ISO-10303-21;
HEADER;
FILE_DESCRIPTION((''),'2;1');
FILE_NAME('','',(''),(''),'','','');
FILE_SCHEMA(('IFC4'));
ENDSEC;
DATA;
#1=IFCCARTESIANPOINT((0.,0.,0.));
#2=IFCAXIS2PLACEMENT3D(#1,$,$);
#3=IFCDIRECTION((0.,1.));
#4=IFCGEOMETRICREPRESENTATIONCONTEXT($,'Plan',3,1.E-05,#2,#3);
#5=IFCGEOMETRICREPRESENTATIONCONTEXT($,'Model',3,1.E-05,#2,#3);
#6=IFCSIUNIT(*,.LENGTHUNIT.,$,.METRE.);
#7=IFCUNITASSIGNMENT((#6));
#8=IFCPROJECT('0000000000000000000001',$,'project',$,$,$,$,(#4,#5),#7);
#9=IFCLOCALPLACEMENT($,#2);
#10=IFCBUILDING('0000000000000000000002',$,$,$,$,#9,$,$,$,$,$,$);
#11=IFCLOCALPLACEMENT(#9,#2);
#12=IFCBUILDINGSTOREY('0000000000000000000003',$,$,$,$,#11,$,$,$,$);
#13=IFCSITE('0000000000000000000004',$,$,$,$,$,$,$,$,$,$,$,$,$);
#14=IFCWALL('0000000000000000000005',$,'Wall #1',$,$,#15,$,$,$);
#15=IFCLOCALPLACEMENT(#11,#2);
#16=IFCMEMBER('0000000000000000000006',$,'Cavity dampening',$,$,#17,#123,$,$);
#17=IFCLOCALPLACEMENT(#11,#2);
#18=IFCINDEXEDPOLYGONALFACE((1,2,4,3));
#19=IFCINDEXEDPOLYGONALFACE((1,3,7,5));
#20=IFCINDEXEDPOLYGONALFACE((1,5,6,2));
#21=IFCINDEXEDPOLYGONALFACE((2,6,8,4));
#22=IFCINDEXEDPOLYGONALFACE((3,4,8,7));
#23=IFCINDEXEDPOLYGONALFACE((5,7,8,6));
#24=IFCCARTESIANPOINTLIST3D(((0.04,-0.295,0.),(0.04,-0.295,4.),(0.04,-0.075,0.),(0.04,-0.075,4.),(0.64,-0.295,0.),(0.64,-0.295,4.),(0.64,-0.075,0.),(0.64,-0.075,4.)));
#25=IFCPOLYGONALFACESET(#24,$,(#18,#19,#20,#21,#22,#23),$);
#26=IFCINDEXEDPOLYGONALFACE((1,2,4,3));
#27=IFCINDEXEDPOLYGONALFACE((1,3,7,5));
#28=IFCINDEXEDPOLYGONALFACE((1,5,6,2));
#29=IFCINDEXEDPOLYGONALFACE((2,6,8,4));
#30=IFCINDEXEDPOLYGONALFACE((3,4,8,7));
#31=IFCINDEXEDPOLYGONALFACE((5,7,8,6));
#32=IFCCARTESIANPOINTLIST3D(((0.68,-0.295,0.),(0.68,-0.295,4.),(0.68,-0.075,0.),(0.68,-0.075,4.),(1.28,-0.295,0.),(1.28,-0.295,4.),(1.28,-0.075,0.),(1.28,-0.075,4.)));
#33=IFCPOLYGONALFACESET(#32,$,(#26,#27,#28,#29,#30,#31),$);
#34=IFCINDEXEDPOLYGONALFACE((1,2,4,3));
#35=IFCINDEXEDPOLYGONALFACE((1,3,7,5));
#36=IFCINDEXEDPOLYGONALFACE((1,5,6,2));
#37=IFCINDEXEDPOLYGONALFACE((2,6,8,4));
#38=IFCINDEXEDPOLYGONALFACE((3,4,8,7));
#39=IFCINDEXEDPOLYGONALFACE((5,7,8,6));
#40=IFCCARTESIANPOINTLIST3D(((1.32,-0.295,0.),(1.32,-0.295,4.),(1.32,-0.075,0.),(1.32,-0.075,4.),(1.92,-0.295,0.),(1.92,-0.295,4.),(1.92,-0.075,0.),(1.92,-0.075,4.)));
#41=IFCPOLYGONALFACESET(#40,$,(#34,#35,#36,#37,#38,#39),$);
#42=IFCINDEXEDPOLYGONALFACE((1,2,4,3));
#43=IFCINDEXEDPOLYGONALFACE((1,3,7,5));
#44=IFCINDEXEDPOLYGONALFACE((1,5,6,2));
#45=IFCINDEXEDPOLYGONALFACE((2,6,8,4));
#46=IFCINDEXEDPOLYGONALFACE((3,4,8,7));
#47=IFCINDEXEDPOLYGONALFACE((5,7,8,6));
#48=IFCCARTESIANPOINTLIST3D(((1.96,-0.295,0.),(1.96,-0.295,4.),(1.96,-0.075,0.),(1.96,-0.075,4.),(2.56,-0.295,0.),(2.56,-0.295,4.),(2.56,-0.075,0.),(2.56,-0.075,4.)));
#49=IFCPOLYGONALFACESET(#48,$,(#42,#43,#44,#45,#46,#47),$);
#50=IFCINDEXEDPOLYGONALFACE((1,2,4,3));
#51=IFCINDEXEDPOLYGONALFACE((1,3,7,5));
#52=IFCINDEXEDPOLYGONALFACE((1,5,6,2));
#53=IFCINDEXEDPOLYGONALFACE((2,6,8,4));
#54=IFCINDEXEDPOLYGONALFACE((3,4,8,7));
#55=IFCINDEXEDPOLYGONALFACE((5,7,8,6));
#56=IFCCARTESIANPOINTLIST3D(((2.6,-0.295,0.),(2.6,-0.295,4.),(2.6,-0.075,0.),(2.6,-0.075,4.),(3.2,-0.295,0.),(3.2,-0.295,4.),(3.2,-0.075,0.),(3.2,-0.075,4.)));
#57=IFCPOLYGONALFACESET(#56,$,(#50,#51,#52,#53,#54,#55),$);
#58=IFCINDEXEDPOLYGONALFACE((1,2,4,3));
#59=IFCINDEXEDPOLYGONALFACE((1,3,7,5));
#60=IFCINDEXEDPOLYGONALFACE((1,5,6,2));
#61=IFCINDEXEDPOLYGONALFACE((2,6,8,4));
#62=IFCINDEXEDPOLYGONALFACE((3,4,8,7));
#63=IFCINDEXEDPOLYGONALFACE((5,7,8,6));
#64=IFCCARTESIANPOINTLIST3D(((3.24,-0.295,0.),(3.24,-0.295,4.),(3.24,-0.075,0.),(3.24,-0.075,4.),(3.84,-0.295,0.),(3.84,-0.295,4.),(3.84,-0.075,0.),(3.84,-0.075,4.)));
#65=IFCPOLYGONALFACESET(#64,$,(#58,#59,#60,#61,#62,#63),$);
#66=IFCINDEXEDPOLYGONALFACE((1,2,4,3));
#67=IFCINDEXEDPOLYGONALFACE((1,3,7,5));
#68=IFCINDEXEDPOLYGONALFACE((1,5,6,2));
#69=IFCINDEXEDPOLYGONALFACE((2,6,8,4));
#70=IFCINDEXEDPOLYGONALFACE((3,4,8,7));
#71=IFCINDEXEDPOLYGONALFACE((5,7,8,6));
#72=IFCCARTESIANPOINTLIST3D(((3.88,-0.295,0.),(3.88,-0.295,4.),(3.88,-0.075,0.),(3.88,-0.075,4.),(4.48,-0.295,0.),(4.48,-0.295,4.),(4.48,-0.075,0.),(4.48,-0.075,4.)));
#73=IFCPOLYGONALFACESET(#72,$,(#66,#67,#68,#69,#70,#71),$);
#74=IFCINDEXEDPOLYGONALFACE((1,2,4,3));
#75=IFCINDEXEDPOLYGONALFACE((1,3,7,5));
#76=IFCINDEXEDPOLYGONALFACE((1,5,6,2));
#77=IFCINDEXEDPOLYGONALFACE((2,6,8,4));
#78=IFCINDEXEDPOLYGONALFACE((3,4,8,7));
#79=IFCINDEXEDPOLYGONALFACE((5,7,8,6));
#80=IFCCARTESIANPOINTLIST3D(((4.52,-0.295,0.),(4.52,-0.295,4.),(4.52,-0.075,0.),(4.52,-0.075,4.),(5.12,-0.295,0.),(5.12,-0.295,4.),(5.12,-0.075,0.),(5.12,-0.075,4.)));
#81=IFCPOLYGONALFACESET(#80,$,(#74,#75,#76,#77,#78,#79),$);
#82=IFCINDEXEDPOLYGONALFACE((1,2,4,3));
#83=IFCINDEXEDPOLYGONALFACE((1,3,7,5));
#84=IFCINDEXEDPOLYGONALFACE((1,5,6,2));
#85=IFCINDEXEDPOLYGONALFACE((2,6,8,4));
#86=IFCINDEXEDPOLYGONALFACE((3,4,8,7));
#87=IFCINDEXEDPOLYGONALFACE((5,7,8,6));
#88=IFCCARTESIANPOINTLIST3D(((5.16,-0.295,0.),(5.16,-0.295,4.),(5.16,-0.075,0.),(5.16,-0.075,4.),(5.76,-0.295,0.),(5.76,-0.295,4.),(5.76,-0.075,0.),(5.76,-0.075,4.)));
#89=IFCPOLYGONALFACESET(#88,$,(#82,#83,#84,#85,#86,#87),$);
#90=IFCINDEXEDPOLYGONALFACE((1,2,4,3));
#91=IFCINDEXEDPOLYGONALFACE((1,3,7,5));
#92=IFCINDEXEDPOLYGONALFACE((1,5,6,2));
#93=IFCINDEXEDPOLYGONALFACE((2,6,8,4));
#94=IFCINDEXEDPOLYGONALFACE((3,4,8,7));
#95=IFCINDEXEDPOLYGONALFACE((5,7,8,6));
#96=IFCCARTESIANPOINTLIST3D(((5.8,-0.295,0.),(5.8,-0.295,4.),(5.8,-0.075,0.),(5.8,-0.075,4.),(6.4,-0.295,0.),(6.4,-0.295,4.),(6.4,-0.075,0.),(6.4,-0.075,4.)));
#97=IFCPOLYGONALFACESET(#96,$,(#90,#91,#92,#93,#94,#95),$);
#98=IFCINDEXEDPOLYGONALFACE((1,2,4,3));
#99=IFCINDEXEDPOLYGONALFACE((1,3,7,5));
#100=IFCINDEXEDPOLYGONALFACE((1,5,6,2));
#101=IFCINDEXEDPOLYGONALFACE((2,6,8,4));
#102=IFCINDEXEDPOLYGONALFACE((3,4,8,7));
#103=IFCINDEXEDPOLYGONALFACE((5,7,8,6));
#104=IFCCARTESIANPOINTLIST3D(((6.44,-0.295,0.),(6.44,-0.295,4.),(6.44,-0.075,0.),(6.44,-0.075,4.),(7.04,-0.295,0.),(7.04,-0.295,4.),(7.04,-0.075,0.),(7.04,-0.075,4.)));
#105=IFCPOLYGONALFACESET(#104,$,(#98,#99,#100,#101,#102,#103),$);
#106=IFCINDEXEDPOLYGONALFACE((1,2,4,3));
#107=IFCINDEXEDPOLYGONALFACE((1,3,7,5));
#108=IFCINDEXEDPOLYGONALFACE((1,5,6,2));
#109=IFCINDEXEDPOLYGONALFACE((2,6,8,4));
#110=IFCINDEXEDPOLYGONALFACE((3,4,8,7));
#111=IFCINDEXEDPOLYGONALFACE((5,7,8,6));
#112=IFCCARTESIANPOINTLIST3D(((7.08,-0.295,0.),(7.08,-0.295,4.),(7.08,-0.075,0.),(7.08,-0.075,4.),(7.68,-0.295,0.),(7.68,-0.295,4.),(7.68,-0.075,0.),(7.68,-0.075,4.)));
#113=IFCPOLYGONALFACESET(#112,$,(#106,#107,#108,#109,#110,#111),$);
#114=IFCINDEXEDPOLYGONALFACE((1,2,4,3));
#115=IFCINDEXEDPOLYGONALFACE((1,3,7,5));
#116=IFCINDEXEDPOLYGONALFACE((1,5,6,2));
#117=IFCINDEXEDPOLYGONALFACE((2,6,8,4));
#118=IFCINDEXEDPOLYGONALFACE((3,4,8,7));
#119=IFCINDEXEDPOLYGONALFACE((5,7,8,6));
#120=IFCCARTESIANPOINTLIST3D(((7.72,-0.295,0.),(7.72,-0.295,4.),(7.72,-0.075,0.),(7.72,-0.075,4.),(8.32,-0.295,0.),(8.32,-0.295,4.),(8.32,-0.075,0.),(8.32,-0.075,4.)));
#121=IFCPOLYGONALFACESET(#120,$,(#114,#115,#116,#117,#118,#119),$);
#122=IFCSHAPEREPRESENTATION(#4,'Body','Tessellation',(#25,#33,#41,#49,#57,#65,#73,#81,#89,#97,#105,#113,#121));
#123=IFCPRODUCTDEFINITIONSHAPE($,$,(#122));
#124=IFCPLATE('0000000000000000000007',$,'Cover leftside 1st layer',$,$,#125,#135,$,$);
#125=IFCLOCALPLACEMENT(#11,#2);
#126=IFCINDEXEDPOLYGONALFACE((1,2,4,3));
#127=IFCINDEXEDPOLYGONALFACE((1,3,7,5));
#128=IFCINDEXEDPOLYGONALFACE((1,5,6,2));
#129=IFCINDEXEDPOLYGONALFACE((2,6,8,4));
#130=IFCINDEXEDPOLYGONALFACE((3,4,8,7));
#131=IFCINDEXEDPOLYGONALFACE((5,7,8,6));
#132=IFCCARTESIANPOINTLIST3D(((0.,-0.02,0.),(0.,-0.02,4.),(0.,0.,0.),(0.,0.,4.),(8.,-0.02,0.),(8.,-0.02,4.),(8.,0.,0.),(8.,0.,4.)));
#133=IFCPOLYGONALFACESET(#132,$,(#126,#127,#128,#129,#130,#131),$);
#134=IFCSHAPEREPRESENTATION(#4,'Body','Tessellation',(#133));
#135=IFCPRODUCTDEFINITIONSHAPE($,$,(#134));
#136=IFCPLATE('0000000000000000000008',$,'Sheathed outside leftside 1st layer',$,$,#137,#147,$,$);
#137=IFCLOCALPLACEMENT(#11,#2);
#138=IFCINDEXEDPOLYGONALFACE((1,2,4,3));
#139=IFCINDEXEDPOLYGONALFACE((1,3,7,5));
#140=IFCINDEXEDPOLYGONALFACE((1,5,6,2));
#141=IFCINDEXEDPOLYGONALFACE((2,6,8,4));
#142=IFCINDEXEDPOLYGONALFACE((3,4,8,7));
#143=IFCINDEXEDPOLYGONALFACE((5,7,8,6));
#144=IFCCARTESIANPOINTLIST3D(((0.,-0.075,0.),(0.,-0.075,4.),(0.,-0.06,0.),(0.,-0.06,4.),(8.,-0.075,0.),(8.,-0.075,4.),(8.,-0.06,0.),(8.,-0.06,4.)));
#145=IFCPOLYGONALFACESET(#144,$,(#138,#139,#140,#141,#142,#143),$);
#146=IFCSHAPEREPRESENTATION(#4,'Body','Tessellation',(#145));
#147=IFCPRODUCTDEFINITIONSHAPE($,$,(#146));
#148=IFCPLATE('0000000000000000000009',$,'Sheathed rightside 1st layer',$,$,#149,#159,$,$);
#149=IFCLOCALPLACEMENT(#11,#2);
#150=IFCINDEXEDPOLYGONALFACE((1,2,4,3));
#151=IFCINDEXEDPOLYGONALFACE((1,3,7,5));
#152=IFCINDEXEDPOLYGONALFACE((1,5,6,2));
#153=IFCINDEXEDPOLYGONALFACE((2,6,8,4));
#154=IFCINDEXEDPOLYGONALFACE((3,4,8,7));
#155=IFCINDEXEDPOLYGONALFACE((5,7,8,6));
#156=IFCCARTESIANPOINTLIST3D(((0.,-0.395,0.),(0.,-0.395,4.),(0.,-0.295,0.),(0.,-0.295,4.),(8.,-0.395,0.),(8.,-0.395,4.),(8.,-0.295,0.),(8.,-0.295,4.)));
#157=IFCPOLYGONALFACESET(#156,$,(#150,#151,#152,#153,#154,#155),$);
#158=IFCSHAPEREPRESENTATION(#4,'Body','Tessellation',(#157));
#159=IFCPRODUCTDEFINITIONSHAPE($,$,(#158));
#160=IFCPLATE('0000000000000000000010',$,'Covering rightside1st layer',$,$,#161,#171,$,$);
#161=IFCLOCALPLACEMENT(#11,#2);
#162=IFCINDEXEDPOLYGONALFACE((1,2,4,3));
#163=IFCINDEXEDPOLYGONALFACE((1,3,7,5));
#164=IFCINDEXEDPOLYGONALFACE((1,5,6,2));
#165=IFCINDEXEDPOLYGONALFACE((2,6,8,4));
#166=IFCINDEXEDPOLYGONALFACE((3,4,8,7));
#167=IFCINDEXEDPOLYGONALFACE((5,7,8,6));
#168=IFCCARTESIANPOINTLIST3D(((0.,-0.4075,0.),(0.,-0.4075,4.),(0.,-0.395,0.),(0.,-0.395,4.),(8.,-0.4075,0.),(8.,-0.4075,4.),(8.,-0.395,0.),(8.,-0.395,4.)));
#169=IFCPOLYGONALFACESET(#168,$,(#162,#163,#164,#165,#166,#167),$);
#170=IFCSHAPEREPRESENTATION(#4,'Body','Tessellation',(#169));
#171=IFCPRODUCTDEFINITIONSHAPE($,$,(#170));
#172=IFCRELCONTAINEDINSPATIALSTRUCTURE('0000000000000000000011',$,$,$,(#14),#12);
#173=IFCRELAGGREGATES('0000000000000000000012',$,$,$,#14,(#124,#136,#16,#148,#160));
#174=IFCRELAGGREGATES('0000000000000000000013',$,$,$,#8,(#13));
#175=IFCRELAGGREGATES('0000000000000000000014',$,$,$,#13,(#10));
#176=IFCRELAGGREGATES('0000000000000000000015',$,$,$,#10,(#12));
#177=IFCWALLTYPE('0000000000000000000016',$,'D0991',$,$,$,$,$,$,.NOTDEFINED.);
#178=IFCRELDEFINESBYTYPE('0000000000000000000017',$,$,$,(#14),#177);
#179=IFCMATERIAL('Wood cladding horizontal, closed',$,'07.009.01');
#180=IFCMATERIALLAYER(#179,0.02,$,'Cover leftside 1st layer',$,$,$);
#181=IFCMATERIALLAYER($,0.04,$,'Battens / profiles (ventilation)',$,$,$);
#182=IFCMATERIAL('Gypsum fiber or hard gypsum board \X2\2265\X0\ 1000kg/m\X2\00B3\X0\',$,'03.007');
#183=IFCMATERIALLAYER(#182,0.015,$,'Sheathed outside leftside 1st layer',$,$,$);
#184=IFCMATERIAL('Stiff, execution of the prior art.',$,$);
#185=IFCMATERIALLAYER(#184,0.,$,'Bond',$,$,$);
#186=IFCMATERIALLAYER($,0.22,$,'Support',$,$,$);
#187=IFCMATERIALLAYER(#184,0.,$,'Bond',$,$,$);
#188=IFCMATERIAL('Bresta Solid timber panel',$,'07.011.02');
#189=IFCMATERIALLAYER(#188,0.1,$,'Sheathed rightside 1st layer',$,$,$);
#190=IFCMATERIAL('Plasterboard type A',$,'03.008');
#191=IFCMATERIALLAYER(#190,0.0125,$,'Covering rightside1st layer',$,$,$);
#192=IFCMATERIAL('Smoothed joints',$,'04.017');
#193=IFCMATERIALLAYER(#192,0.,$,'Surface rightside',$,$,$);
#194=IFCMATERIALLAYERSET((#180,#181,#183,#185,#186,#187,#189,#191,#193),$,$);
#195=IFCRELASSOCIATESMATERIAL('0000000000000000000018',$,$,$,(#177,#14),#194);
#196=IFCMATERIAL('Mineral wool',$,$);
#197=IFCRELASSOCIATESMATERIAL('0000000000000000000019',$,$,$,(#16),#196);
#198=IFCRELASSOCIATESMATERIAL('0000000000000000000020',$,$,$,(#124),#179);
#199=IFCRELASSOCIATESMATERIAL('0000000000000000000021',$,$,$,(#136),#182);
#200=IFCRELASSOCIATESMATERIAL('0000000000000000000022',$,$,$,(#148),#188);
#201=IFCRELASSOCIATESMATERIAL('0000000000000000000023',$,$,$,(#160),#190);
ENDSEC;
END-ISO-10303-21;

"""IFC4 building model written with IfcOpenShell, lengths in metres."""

from ifc_helpers import new_model, si_unit, direction, frame, frame_2d, origin, origin_with_axes, place, context, project, spatial, rectangle, extrude, material, layer, layer_set, type_object, element, aggregate, save


model = new_model("IFC4")

# Units and contexts
plan_context = context("Plan", 3, precision=1e-05, world=origin(), true_north=direction((0.0, 1.0)))
model_context = context("Model", 3, precision=1e-05, world=origin(), true_north=direction((0.0, 1.0)))
ifc_project = project(units=[si_unit("LENGTHUNIT", "METRE")], contexts=[plan_context, model_context])

# Site, building, storey
site = spatial("IfcSite", under=ifc_project)
building_placement = place(None, origin())
building = spatial("IfcBuilding", under=site, at=building_placement)
storey_placement = place(building_placement, origin())
storey = spatial("IfcBuildingStorey", under=building, at=storey_placement)

# Wall, member, plates
ifc_material_1 = material(Name="Wood cladding horizontal, closed", Category="07.009.01")
ifc_layer_1 = layer(ifc_material_1, 0.02, Name="Cover leftside 1st layer")
ifc_layer_2 = layer(None, 0.04, Name="Battens / profiles (ventilation)")
ifc_material_2 = material(Name="Gypsum fiber or hard gypsum board ≥ 1000kg/m³", Category="03.007")
ifc_layer_3 = layer(ifc_material_2, 0.015, Name="Sheathed outside leftside 1st layer")
ifc_material_3 = material(Name="Stiff, execution of the prior art.")
ifc_layer_4 = layer(ifc_material_3, 0.0, Name="Bond")
ifc_layer_5 = layer(None, 0.22, Name="Support")
ifc_layer_6 = layer(ifc_material_3, 0.0, Name="Bond")
ifc_material_4 = material(Name="Bresta Solid timber panel", Category="07.011.02")
ifc_layer_7 = layer(ifc_material_4, 0.1, Name="Sheathed rightside 1st layer")
ifc_material_5 = material(Name="Plasterboard type A", Category="03.008")
ifc_layer_8 = layer(ifc_material_5, 0.0125, Name="Covering rightside1st layer")
ifc_material_6 = material(Name="Smoothed joints", Category="04.017")
ifc_layer_9 = layer(ifc_material_6, 0.0, Name="Surface rightside")
ifc_layer_set = layer_set([ifc_layer_1, ifc_layer_2, ifc_layer_3, ifc_layer_4, ifc_layer_5, ifc_layer_6, ifc_layer_7, ifc_layer_8, ifc_layer_9])
wall_type = type_object("IfcWallType", Name="D0991", PredefinedType="NOTDEFINED", material=ifc_layer_set)
wall_placement = place(None, frame((0.0, 0.0, 0.0), z_axis=(0.0, -1.0, 0.0), x_axis=(1.0, 0.0, 0.0)))
wall = element("IfcWall", 1, at=wall_placement, inside=storey, type_object=wall_type, material=ifc_layer_set, Name="Wall #1")
ifc_material_7 = material(Name="Mineral wool")
member_1_placement = place(wall_placement, origin())
member_1 = element("IfcMember", 2, at=member_1_placement, material=ifc_material_7, Name="Cavity dampening", context=plan_context, shape_type="SweptSolid", body=[
    extrude(rectangle(XDim=0.6, YDim=0.22, at=frame_2d((0.3, 0.11), x_axis=(1.0, 0.0))), frame((0.04, 4.0, 0.075), z_axis=(0.0, -1.0, 0.0), x_axis=(1.0, 0.0, 0.0)), (0.0, 0.0, 1.0), 4.0),
    extrude(rectangle(XDim=0.6, YDim=0.22, at=frame_2d((0.3, 0.11), x_axis=(1.0, 0.0))), frame((0.68, 4.0, 0.075), z_axis=(0.0, -1.0, 0.0), x_axis=(1.0, 0.0, 0.0)), (0.0, 0.0, 1.0), 4.0),
    extrude(rectangle(XDim=0.6, YDim=0.22, at=frame_2d((0.3, 0.11), x_axis=(1.0, 0.0))), frame((1.32, 4.0, 0.075), z_axis=(0.0, -1.0, 0.0), x_axis=(1.0, 0.0, 0.0)), (0.0, 0.0, 1.0), 4.0),
    extrude(rectangle(XDim=0.6, YDim=0.22, at=frame_2d((0.3, 0.11), x_axis=(1.0, 0.0))), frame((1.96, 4.0, 0.075), z_axis=(0.0, -1.0, 0.0), x_axis=(1.0, 0.0, 0.0)), (0.0, 0.0, 1.0), 4.0),
    extrude(rectangle(XDim=0.6, YDim=0.22, at=frame_2d((0.3, 0.11), x_axis=(1.0, 0.0))), frame((2.6, 4.0, 0.075), z_axis=(0.0, -1.0, 0.0), x_axis=(1.0, 0.0, 0.0)), (0.0, 0.0, 1.0), 4.0),
    extrude(rectangle(XDim=0.6, YDim=0.22, at=frame_2d((0.3, 0.11), x_axis=(1.0, 0.0))), frame((3.24, 4.0, 0.075), z_axis=(0.0, -1.0, 0.0), x_axis=(1.0, 0.0, 0.0)), (0.0, 0.0, 1.0), 4.0),
    extrude(rectangle(XDim=0.6, YDim=0.22, at=frame_2d((0.3, 0.11), x_axis=(1.0, 0.0))), frame((3.88, 4.0, 0.075), z_axis=(0.0, -1.0, 0.0), x_axis=(1.0, 0.0, 0.0)), (0.0, 0.0, 1.0), 4.0),
    extrude(rectangle(XDim=0.6, YDim=0.22, at=frame_2d((0.3, 0.11), x_axis=(1.0, 0.0))), frame((4.52, 4.0, 0.075), z_axis=(0.0, -1.0, 0.0), x_axis=(1.0, 0.0, 0.0)), (0.0, 0.0, 1.0), 4.0),
    extrude(rectangle(XDim=0.6, YDim=0.22, at=frame_2d((0.3, 0.11), x_axis=(1.0, 0.0))), frame((5.16, 4.0, 0.075), z_axis=(0.0, -1.0, 0.0), x_axis=(1.0, 0.0, 0.0)), (0.0, 0.0, 1.0), 4.0),
    extrude(rectangle(XDim=0.6, YDim=0.22, at=frame_2d((0.3, 0.11), x_axis=(1.0, 0.0))), frame((5.8, 4.0, 0.075), z_axis=(0.0, -1.0, 0.0), x_axis=(1.0, 0.0, 0.0)), (0.0, 0.0, 1.0), 4.0),
    extrude(rectangle(XDim=0.6, YDim=0.22, at=frame_2d((0.3, 0.11), x_axis=(1.0, 0.0))), frame((6.44, 4.0, 0.075), z_axis=(0.0, -1.0, 0.0), x_axis=(1.0, 0.0, 0.0)), (0.0, 0.0, 1.0), 4.0),
    extrude(rectangle(XDim=0.6, YDim=0.22, at=frame_2d((0.3, 0.11), x_axis=(1.0, 0.0))), frame((7.08, 4.0, 0.075), z_axis=(0.0, -1.0, 0.0), x_axis=(1.0, 0.0, 0.0)), (0.0, 0.0, 1.0), 4.0),
    extrude(rectangle(XDim=0.6, YDim=0.22, at=frame_2d((0.3, 0.11), x_axis=(1.0, 0.0))), frame((7.72, 4.0, 0.075), z_axis=(0.0, -1.0, 0.0), x_axis=(1.0, 0.0, 0.0)), (0.0, 0.0, 1.0), 4.0),
])
plate_1_placement = place(wall_placement, origin())
plate_1 = element("IfcPlate", 3, at=plate_1_placement, material=ifc_material_1, Name="Cover leftside 1st layer", context=plan_context, shape_type="SweptSolid", body=[
    extrude(rectangle(XDim=8.0, YDim=4.0, at=frame_2d((4.0, 2.0), x_axis=(1.0, 0.0))), origin_with_axes(), (0.0, 0.0, 1.0), 0.02),
])
plate_2_placement = place(wall_placement, origin())
plate_2 = element("IfcPlate", 4, at=plate_2_placement, material=ifc_material_2, Name="Sheathed outside leftside 1st layer", context=plan_context, shape_type="SweptSolid", body=[
    extrude(rectangle(XDim=8.0, YDim=4.0, at=frame_2d((4.0, 2.0), x_axis=(1.0, 0.0))), frame((0.0, 0.0, 0.06), z_axis=(0.0, 0.0, 1.0), x_axis=(1.0, 0.0, 0.0)), (0.0, 0.0, 1.0), 0.015),
])
plate_3_placement = place(wall_placement, origin())
plate_3 = element("IfcPlate", 5, at=plate_3_placement, material=ifc_material_4, Name="Sheathed rightside 1st layer", context=plan_context, shape_type="SweptSolid", body=[
    extrude(rectangle(XDim=8.0, YDim=4.0, at=frame_2d((4.0, 2.0), x_axis=(1.0, 0.0))), frame((0.0, 0.0, 0.295), z_axis=(0.0, 0.0, 1.0), x_axis=(1.0, 0.0, 0.0)), (0.0, 0.0, 1.0), 0.1),
])
plate_4_placement = place(wall_placement, origin())
plate_4 = element("IfcPlate", 6, at=plate_4_placement, material=ifc_material_5, Name="Covering rightside1st layer", context=plan_context, shape_type="SweptSolid", body=[
    extrude(rectangle(XDim=8.0, YDim=4.0, at=frame_2d((4.0, 2.0), x_axis=(1.0, 0.0))), frame((0.0, 0.0, 0.395), z_axis=(0.0, 0.0, 1.0), x_axis=(1.0, 0.0, 0.0)), (0.0, 0.0, 1.0), 0.0125),
])
aggregate(wall, [plate_1, plate_2, member_1, plate_3, plate_4])

save(model, "model.ifc")
